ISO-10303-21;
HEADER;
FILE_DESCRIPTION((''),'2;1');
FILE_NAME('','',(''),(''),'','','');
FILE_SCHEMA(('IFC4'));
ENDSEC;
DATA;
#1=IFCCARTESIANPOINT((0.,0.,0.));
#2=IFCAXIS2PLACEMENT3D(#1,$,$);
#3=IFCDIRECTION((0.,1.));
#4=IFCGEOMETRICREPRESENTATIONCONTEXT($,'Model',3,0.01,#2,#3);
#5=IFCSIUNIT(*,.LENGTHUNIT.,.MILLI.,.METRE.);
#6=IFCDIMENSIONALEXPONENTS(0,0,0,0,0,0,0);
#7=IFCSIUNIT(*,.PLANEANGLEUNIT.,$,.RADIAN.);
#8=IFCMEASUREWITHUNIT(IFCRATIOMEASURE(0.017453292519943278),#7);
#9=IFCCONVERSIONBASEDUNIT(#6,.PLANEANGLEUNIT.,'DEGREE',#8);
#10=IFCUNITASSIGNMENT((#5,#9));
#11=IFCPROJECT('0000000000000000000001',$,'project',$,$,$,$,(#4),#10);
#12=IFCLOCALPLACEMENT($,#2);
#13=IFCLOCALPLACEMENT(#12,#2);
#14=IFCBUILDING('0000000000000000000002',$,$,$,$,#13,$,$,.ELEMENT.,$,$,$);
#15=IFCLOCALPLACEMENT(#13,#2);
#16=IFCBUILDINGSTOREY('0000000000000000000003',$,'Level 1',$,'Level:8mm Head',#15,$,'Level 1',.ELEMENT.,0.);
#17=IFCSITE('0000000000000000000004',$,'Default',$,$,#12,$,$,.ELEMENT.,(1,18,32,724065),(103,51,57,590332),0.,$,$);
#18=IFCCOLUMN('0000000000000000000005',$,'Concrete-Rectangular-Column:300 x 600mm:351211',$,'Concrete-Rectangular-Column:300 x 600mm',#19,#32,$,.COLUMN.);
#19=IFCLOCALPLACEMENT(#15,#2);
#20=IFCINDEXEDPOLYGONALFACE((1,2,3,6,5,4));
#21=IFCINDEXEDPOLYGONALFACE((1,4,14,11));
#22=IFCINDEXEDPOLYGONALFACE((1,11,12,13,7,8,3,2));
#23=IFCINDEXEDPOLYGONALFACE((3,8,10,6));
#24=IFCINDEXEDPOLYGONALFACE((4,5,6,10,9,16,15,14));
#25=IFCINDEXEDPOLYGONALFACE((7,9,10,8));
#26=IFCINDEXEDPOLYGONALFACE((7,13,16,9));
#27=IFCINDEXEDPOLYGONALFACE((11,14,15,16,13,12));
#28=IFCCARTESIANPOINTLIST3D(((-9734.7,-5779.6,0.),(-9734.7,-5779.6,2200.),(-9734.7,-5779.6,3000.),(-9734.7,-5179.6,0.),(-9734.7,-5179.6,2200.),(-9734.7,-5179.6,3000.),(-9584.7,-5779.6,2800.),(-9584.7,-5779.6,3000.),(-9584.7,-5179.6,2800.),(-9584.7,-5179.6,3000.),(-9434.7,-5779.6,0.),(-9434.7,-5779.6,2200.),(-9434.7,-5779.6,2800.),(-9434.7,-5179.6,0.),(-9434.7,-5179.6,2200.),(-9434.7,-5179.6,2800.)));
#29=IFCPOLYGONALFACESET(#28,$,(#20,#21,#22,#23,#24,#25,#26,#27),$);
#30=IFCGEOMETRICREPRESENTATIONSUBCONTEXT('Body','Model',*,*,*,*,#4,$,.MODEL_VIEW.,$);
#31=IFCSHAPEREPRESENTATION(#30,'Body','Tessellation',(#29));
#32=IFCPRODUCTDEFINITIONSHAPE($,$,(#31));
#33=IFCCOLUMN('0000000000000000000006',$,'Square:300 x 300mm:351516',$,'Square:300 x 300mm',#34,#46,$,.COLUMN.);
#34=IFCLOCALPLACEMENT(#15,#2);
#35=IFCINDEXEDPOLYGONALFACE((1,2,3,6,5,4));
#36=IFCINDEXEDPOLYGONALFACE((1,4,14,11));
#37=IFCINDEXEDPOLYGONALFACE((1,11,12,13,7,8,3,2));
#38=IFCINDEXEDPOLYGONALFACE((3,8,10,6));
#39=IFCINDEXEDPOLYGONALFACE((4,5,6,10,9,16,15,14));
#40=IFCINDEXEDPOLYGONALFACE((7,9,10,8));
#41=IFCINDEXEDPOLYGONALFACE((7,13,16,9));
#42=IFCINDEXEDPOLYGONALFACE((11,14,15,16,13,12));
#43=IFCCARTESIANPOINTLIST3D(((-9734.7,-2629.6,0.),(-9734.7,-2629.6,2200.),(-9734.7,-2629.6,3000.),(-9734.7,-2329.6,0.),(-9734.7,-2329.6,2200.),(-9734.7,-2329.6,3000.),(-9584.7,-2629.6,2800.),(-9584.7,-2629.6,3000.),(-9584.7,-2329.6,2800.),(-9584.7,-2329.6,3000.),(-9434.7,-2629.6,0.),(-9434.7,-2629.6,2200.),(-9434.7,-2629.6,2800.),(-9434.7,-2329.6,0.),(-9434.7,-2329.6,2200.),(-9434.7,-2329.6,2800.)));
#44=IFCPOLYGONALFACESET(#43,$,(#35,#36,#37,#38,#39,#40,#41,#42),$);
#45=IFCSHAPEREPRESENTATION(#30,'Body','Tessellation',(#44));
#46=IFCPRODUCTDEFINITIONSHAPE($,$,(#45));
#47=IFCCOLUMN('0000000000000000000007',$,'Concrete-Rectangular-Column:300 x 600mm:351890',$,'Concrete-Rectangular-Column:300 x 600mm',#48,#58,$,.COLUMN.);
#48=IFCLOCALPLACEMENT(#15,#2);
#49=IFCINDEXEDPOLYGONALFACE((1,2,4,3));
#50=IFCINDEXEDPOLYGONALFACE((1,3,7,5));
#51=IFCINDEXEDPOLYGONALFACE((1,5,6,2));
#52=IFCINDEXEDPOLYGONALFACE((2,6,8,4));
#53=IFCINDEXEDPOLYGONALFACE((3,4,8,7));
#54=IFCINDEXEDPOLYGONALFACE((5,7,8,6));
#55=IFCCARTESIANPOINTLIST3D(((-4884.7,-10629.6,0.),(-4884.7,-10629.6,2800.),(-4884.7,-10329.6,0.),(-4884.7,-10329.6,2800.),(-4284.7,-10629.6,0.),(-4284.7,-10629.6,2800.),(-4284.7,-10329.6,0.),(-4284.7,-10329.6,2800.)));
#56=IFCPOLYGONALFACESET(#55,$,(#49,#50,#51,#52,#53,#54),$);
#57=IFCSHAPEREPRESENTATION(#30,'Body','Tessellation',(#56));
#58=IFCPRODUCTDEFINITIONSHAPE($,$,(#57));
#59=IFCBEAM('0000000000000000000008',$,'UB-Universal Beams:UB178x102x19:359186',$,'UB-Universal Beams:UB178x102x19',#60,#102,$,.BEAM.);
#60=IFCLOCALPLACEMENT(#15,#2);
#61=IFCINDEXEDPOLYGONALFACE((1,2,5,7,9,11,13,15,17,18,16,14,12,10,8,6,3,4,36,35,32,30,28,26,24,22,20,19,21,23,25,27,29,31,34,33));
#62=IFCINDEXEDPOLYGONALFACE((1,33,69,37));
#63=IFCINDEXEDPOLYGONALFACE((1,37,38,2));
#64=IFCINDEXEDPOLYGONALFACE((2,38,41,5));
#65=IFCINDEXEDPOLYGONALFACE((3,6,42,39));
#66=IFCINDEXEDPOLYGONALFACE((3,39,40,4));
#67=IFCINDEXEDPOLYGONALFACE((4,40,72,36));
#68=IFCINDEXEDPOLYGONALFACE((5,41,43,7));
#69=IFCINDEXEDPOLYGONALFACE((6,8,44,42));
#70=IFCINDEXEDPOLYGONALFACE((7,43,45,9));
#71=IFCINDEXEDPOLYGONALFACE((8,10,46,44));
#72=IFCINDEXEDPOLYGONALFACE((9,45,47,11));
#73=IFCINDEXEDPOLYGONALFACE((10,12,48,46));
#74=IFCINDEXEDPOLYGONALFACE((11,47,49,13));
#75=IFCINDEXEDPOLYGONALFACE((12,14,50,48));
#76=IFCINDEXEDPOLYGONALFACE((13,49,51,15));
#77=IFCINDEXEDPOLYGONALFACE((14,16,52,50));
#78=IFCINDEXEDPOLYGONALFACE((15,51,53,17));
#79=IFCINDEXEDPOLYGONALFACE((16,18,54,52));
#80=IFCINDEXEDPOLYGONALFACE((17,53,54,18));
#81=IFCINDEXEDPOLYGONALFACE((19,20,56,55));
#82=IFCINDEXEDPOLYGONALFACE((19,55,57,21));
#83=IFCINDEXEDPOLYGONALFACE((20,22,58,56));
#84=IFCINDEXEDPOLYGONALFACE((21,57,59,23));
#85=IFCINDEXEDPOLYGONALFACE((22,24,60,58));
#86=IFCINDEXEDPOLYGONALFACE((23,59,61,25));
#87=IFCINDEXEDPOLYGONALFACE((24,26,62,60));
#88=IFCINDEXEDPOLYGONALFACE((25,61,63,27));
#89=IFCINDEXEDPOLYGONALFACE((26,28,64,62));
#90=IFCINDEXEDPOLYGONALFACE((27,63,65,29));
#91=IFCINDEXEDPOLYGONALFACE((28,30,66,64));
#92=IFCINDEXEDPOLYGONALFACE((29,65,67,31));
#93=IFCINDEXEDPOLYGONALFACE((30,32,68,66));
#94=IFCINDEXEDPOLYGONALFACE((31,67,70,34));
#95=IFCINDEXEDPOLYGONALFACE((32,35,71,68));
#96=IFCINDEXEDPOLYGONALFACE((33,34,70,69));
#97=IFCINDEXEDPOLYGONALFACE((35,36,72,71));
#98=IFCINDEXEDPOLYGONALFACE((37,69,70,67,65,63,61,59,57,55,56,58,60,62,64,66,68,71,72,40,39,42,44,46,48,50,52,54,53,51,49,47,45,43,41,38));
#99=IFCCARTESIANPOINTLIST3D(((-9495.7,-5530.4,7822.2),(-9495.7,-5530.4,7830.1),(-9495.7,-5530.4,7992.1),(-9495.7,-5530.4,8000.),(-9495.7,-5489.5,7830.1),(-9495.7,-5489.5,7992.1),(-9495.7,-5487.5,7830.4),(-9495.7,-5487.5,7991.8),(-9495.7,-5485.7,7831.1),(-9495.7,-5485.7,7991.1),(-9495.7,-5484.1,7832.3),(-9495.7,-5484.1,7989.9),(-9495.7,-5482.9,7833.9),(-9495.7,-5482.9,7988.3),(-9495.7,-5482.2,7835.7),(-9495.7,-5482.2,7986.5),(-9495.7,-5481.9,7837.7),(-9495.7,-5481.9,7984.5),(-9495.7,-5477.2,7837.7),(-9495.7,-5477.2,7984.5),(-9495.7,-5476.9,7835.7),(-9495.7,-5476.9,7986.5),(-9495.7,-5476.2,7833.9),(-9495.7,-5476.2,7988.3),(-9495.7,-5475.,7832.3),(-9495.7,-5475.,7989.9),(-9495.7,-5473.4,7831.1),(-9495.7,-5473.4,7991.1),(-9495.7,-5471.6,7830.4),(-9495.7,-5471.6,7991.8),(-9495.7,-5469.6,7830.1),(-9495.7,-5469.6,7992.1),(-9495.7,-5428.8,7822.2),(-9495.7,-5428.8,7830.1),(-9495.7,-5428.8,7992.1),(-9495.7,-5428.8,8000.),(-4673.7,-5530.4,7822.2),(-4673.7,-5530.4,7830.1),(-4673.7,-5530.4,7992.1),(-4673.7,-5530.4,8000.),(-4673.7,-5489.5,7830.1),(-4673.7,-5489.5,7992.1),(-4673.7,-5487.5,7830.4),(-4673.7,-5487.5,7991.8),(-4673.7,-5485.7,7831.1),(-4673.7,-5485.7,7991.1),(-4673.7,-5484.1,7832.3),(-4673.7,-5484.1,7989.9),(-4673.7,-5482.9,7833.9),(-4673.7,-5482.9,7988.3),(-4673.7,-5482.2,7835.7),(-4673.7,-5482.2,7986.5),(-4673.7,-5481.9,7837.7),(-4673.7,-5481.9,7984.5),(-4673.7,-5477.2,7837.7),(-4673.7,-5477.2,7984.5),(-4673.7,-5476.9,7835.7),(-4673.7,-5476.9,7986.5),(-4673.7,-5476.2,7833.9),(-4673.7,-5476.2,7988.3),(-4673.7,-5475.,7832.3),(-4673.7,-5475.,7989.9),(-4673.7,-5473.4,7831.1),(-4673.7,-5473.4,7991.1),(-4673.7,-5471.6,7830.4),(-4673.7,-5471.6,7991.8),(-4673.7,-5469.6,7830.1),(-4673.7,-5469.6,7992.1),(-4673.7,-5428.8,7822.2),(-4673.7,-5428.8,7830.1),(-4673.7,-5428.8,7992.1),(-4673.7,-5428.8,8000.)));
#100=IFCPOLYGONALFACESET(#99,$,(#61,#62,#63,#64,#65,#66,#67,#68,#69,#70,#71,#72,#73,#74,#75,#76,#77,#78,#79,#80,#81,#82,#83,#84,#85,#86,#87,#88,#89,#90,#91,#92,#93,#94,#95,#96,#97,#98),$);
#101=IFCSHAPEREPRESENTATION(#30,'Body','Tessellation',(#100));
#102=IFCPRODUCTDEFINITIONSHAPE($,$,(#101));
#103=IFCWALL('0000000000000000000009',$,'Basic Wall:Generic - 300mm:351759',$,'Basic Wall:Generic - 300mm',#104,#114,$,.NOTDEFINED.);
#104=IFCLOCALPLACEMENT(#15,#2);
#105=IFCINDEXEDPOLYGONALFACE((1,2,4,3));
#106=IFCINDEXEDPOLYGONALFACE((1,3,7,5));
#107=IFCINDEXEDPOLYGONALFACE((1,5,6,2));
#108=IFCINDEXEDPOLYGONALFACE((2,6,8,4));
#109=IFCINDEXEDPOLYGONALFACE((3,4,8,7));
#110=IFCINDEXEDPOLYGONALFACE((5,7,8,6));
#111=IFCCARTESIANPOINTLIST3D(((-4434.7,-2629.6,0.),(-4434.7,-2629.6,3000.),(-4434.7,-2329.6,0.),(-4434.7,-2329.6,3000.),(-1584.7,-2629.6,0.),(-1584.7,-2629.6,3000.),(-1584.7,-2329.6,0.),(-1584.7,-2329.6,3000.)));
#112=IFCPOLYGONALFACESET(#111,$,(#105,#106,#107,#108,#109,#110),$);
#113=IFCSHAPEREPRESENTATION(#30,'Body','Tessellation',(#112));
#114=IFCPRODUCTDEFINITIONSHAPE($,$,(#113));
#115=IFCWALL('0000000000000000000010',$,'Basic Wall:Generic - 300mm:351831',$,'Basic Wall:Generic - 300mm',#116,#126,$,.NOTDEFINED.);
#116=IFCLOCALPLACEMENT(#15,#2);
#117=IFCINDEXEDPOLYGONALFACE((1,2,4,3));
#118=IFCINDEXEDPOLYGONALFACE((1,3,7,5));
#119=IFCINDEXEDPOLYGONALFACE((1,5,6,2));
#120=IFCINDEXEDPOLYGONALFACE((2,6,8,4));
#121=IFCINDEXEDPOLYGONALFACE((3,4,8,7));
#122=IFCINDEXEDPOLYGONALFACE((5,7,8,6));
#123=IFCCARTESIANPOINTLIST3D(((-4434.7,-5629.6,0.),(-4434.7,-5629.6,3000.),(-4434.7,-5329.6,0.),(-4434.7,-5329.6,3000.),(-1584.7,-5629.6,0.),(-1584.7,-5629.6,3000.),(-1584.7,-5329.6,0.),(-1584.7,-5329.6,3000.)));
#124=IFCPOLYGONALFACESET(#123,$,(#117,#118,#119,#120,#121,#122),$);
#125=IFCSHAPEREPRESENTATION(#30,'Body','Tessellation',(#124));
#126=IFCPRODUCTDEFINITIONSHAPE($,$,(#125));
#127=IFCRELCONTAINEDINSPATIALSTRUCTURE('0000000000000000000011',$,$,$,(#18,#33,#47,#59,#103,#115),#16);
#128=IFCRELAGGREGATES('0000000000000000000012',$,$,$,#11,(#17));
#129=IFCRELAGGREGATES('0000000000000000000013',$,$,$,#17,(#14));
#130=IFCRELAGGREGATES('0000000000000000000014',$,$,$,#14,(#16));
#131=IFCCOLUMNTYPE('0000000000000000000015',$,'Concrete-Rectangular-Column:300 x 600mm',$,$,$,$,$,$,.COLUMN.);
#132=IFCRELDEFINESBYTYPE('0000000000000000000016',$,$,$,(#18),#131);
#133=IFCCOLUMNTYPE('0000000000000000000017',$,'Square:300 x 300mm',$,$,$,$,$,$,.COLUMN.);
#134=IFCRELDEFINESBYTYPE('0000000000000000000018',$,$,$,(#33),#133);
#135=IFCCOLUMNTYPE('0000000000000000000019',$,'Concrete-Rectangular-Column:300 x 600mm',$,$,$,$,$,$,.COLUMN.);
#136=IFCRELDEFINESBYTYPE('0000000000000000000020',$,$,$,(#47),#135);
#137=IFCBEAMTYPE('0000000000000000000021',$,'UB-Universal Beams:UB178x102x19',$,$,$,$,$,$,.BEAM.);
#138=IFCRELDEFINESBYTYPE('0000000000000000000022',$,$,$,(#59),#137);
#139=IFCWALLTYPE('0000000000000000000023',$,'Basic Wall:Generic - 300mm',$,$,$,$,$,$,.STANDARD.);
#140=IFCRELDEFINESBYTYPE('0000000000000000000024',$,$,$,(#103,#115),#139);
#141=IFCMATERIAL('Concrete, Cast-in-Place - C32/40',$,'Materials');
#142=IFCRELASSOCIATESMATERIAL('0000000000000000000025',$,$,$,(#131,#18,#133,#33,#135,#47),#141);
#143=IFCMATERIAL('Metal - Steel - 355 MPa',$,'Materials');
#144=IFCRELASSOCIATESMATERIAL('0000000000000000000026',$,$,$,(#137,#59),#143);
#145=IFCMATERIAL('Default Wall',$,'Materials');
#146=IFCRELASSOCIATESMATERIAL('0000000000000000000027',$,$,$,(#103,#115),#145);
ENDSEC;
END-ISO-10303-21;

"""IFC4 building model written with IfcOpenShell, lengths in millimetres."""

from ifc_helpers import new_model, entity, si_unit, converted_unit, direction, frame, origin, place, context, subcontext, project, spatial, line, arc, indexed_curve, outline, extrude, source, transform, mapped, material, type_object, type_shapes, element, save


model = new_model("IFC4")

# Units and contexts
model_context = context("Model", 3, precision=0.01, world=origin(), true_north=direction((0.0, 1.0)))
body_context = subcontext(model_context, "Body", "Model", "MODEL_VIEW")
ifc_project = project(units=[si_unit("LENGTHUNIT", "METRE", prefix="MILLI"), converted_unit("PLANEANGLEUNIT", "DEGREE", entity("IfcRatioMeasure", 0.017453292519943278), si_unit("PLANEANGLEUNIT", "RADIAN"), dimensions=[0, 0, 0, 0, 0, 0, 0])], contexts=[model_context])

# Site, building, storey
site_placement = place(None, origin())
site = spatial("IfcSite", under=ifc_project, at=site_placement, Name="Default", CompositionType="ELEMENT", RefLatitude=(1, 18, 32, 724065), RefLongitude=(103, 51, 57, 590332), RefElevation=0.0)
building_placement = place(site_placement, origin())
building = spatial("IfcBuilding", under=site, at=building_placement, CompositionType="ELEMENT")
storey_placement = place(building_placement, origin())
storey = spatial("IfcBuildingStorey", under=building, at=storey_placement, Name="Level 1", ObjectType="Level:8mm Head", LongName="Level 1", CompositionType="ELEMENT", Elevation=0.0)

# Columns
ifc_material_1 = material(Name="Concrete, Cast-in-Place - C32/40", Category="Materials")
column_type_1 = type_object("IfcColumnType", Name="Concrete-Rectangular-Column:300 x 600mm", PredefinedType="COLUMN", material=ifc_material_1)
shared_shape_1 = source(origin(), body_context, "Body", "SweptSolid", [
    extrude(outline(indexed_curve([(-2000.0, -150.0), (200.0, -150.0), (1000.0, -150.0), (1000.0, 0.0), (800.0, 0.0), (800.0, 150.0), (200.0, 150.0), (-2000.0, 150.0), (-2000.0, -150.0)], self_intersect=False)), frame((-9584.7, -5779.6, 2000.0), z_axis=(0.0, 1.0, 0.0), x_axis=(0.0, 0.0, 1.0)), (0.0, 0.0, 1.0), 600.0),
])
type_shapes(column_type_1, [shared_shape_1])
column_1_placement = place(storey_placement, origin())
element("IfcColumn", 1, at=column_1_placement, inside=storey, type_object=column_type_1, material=ifc_material_1, Name="Concrete-Rectangular-Column:300 x 600mm:351211", ObjectType="Concrete-Rectangular-Column:300 x 600mm", PredefinedType="COLUMN", context=body_context, shape_type="MappedRepresentation", body=[
    mapped(shared_shape_1, transform((0.0, 0.0, 0.0), scale=1.0)),
])
column_type_2 = type_object("IfcColumnType", Name="Square:300 x 300mm", PredefinedType="COLUMN", material=ifc_material_1)
shared_shape_2 = source(origin(), body_context, "Body", "SweptSolid", [
    extrude(outline(indexed_curve([(-2000.0, -150.0), (200.0, -150.0), (1000.0, -150.0), (1000.0, 0.0), (800.0, 0.0), (800.0, 150.0), (200.0, 150.0), (-2000.0, 150.0), (-2000.0, -150.0)], self_intersect=False)), frame((-9584.7, -2629.6, 2000.0), z_axis=(0.0, 1.0, 0.0), x_axis=(0.0, 0.0, 1.0)), (0.0, 0.0, 1.0), 300.0),
])
type_shapes(column_type_2, [shared_shape_2])
column_2_placement = place(storey_placement, origin())
element("IfcColumn", 2, at=column_2_placement, inside=storey, type_object=column_type_2, material=ifc_material_1, Name="Square:300 x 300mm:351516", ObjectType="Square:300 x 300mm", PredefinedType="COLUMN", context=body_context, shape_type="MappedRepresentation", body=[
    mapped(shared_shape_2, transform((0.0, 0.0, 0.0), scale=1.0)),
])
column_type_3 = type_object("IfcColumnType", Name="Concrete-Rectangular-Column:300 x 600mm", PredefinedType="COLUMN", material=ifc_material_1)
shared_shape_3 = source(origin(), body_context, "Body", "SweptSolid", [
    extrude(outline(indexed_curve([(-150.0, -300.0), (150.0, -300.0), (150.0, 300.0), (-150.0, 300.0), (-150.0, -300.0)], self_intersect=False)), frame((-4584.7, -10479.6, 0.0), z_axis=(0.0, 0.0, 1.0), x_axis=(0.0, -1.0, 0.0)), (0.0, 0.0, 1.0), 2800.0),
])
type_shapes(column_type_3, [shared_shape_3])
column_3_placement = place(storey_placement, origin())
element("IfcColumn", 3, at=column_3_placement, inside=storey, type_object=column_type_3, material=ifc_material_1, Name="Concrete-Rectangular-Column:300 x 600mm:351890", ObjectType="Concrete-Rectangular-Column:300 x 600mm", PredefinedType="COLUMN", context=body_context, shape_type="MappedRepresentation", body=[
    mapped(shared_shape_3, transform((0.0, 0.0, 0.0), scale=1.0)),
])

# Beam
ifc_material_2 = material(Name="Metal - Steel - 355 MPa", Category="Materials")
beam_type = type_object("IfcBeamType", Name="UB-Universal Beams:UB178x102x19", PredefinedType="BEAM", material=ifc_material_2)
shared_shape_4 = source(origin(), body_context, "Body", "SweptSolid", [
    extrude(outline(indexed_curve([(-88.9, -50.8), (-81.0, -50.8), (-81.0, -9.9), (-78.8, -4.6), (-73.4, -2.3), (73.4, -2.3), (78.8, -4.6), (81.0, -9.9), (81.0, -50.8), (88.9, -50.8), (88.9, 50.8), (81.0, 50.8), (81.0, 10.0), (78.8, 4.6), (73.4, 2.4), (-73.4, 2.4), (-78.8, 4.6), (-81.0, 10.0), (-81.0, 50.8), (-88.9, 50.8)], segments=[line(1, 2, 3), arc(3, 4, 5), line(5, 6), arc(6, 7, 8), line(8, 9, 10, 11, 12, 13), arc(13, 14, 15), line(15, 16), arc(16, 17, 18), line(18, 19, 20, 1)], self_intersect=False)), frame((-2411.0, 0.0, 0.0), z_axis=(1.0, 0.0, 0.0), x_axis=(0.0, 0.0, -1.0)), (0.0, 0.0, 1.0), 4822.0),
])
type_shapes(beam_type, [shared_shape_4])
beam_placement = place(storey_placement, frame((-7084.7, -5479.6, 7911.1), z_axis=(0.0, 0.0, 1.0), x_axis=(-1.0, 0.0, 0.0)))
element("IfcBeam", 4, at=beam_placement, inside=storey, type_object=beam_type, material=ifc_material_2, Name="UB-Universal Beams:UB178x102x19:359186", ObjectType="UB-Universal Beams:UB178x102x19", PredefinedType="BEAM", context=body_context, shape_type="MappedRepresentation", body=[
    mapped(shared_shape_4, transform((0.0, 0.0, 0.0), scale=1.0)),
])

# Walls
ifc_material_3 = material(Name="Default Wall", Category="Materials")
wall_type = type_object("IfcWallType", Name="Basic Wall:Generic - 300mm", PredefinedType="STANDARD")
wall_1_placement = place(storey_placement, frame((-1584.7, -2479.6, 0.0), z_axis=(0.0, 0.0, 1.0), x_axis=(-1.0, 0.0, 0.0)))
element("IfcWall", 5, at=wall_1_placement, inside=storey, type_object=wall_type, material=ifc_material_3, Name="Basic Wall:Generic - 300mm:351759", ObjectType="Basic Wall:Generic - 300mm", PredefinedType="NOTDEFINED", context=body_context, shape_type="SweptSolid", body=[
    extrude(outline(indexed_curve([(2850.0, 150.0), (0.0, 150.0), (0.0, -150.0), (2850.0, -150.0), (2850.0, 150.0)], self_intersect=False)), origin(), (0.0, 0.0, 1.0), 3000.0),
])
wall_2_placement = place(storey_placement, frame((-1584.7, -5479.6, 0.0), z_axis=(0.0, 0.0, 1.0), x_axis=(-1.0, 0.0, 0.0)))
element("IfcWall", 6, at=wall_2_placement, inside=storey, type_object=wall_type, material=ifc_material_3, Name="Basic Wall:Generic - 300mm:351831", ObjectType="Basic Wall:Generic - 300mm", PredefinedType="NOTDEFINED", context=body_context, shape_type="SweptSolid", body=[
    extrude(outline(indexed_curve([(2850.0, 150.0), (0.0, 150.0), (0.0, -150.0), (2850.0, -150.0), (2850.0, 150.0)], self_intersect=False)), origin(), (0.0, 0.0, 1.0), 3000.0),
])

save(model, "model.ifc")
